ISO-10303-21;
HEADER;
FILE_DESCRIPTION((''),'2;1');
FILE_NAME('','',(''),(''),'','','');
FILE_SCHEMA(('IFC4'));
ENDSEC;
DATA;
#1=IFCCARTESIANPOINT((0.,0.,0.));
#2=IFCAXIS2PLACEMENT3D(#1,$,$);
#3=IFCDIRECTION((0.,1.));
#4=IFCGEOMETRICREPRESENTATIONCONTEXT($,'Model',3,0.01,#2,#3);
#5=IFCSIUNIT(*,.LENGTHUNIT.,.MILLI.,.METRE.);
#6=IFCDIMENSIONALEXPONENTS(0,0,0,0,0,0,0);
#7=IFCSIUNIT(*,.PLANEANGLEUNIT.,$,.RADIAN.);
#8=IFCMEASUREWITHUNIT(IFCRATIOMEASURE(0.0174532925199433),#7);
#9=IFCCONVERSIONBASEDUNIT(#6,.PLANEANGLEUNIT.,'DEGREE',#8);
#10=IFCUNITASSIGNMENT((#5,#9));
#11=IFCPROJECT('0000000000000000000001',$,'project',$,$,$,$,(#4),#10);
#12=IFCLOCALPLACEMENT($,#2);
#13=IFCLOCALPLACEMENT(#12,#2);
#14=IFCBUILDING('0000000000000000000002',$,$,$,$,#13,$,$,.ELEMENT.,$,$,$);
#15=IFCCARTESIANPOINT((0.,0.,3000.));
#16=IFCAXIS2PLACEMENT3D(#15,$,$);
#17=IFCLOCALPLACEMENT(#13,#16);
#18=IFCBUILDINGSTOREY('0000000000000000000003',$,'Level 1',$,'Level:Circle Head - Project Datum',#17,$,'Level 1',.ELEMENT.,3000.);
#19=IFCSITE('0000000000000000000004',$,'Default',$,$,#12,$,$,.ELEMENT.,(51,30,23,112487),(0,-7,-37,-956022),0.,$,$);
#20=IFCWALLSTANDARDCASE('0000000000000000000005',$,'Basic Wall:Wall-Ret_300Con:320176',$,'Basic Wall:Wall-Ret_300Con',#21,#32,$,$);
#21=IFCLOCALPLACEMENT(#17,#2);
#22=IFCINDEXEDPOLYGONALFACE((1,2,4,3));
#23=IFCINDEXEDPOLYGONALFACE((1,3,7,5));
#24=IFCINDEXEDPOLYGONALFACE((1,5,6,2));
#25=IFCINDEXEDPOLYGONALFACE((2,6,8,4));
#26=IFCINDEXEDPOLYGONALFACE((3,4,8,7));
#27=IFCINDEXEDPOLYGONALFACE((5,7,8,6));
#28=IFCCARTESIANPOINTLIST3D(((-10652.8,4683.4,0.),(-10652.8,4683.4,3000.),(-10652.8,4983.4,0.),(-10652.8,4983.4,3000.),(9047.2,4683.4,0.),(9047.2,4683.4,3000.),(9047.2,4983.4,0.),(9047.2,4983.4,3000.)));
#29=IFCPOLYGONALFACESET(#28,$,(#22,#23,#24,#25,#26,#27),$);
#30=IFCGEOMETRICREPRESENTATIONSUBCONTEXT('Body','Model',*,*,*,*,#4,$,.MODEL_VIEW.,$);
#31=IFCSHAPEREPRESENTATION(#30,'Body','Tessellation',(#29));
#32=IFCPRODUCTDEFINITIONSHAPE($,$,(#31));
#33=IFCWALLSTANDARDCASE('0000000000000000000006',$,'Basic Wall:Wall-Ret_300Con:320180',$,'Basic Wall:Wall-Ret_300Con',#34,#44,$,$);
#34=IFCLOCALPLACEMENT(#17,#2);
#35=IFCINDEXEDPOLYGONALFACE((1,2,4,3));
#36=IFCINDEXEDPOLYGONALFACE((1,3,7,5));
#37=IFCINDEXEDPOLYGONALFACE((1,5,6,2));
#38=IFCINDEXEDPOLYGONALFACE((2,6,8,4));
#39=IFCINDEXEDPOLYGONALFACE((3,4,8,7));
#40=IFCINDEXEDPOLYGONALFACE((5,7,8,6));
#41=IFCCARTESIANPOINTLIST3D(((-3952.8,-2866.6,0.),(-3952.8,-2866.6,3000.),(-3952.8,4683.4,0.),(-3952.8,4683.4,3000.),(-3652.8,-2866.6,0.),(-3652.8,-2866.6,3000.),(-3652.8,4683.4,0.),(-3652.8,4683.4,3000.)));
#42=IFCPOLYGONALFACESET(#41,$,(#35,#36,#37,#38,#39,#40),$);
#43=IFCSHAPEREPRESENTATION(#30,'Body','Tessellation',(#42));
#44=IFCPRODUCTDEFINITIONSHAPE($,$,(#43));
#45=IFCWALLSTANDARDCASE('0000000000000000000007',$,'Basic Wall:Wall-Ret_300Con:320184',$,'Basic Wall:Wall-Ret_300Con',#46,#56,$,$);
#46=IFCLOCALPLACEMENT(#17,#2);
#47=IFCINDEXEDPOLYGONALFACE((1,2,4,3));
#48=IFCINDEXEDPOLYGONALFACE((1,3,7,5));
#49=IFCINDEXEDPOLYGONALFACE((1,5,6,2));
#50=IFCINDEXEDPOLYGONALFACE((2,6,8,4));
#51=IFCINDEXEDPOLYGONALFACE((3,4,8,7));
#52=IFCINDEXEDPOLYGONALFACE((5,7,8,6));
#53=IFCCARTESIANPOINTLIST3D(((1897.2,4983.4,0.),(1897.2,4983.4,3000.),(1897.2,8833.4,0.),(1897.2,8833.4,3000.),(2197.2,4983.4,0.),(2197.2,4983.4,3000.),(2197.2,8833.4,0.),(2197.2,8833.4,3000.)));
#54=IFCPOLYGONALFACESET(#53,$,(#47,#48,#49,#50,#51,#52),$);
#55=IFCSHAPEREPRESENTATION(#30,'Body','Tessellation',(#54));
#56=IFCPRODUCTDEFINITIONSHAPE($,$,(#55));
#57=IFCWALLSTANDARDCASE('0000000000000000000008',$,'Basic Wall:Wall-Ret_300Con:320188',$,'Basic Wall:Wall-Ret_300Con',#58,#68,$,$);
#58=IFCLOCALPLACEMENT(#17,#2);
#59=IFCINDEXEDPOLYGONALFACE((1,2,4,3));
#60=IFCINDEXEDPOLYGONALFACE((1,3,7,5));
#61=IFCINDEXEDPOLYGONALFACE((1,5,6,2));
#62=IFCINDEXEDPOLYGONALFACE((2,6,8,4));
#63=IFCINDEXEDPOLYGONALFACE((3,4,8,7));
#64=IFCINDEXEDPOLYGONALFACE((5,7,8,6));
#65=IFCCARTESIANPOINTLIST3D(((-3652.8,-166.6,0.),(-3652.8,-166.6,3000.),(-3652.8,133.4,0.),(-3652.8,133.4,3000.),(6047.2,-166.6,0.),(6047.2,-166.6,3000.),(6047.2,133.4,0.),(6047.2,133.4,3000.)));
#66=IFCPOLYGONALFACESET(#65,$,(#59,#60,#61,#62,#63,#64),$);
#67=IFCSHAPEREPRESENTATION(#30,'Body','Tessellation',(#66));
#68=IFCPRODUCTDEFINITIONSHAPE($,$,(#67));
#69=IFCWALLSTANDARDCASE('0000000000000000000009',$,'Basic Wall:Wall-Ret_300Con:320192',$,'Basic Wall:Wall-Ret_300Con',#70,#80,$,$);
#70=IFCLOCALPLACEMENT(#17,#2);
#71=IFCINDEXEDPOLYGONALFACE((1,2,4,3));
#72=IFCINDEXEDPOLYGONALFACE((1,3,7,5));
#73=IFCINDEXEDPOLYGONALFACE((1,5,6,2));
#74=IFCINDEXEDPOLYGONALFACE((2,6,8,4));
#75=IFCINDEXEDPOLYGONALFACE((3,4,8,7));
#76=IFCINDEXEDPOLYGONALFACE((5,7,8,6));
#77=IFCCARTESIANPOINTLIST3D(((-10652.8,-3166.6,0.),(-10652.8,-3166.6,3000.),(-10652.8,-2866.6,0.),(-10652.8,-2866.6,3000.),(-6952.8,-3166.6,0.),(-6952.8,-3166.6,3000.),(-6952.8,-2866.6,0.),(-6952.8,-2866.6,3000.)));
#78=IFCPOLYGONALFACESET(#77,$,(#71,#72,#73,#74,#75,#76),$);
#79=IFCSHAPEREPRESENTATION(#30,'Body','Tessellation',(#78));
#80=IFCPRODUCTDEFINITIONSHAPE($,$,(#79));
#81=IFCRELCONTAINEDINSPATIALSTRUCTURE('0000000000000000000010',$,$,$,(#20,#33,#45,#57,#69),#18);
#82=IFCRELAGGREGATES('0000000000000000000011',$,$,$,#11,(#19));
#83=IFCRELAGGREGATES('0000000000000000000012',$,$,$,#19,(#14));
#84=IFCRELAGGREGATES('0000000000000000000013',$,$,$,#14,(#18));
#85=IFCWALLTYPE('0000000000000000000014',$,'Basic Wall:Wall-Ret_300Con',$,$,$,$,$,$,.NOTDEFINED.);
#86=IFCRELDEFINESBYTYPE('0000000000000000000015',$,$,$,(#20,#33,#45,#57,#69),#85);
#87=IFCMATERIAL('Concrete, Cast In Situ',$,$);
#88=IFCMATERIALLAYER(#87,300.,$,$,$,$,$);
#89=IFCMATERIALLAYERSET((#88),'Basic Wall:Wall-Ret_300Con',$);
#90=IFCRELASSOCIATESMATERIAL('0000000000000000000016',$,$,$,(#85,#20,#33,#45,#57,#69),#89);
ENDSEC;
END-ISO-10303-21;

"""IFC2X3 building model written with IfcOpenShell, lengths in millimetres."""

from ifc_helpers import new_model, entity, si_unit, converted_unit, direction, frame, frame_2d, origin, place, context, subcontext, project, spatial, rectangle, extrude, material, layer, layer_set, layer_usage, type_object, element, save


model = new_model("IFC2X3")

# Units and contexts
model_context = context("Model", 3, precision=0.01, world=origin(), true_north=direction((0.0, 1.0)))
body_context = subcontext(model_context, "Body", "Model", "MODEL_VIEW")
ifc_project = project(units=[si_unit("LENGTHUNIT", "METRE", prefix="MILLI"), converted_unit("PLANEANGLEUNIT", "DEGREE", entity("IfcRatioMeasure", 0.0174532925199433), si_unit("PLANEANGLEUNIT", "RADIAN"), dimensions=[0, 0, 0, 0, 0, 0, 0])], contexts=[model_context])

# Site, building, storey
site_placement = place(None, origin())
site = spatial("IfcSite", under=ifc_project, at=site_placement, Name="Default", CompositionType="ELEMENT", RefLatitude=(51, 30, 23, 112487), RefLongitude=(0, -7, -37, -956022), RefElevation=0.0)
building_placement = place(site_placement, origin())
building = spatial("IfcBuilding", under=site, at=building_placement, CompositionType="ELEMENT")
storey_placement = place(building_placement, frame((0.0, 0.0, 3000.0)))
storey = spatial("IfcBuildingStorey", under=building, at=storey_placement, Name="Level 1", ObjectType="Level:Circle Head - Project Datum", LongName="Level 1", CompositionType="ELEMENT", Elevation=3000.0)

# Walls
ifc_material_1 = material(Name="Concrete, Cast In Situ")
ifc_layer_1 = layer(ifc_material_1, 300.0)
ifc_layer_set_1 = layer_set([ifc_layer_1], Name="Basic Wall:Wall-Ret_300Con")
wall_type = type_object("IfcWallType", Name="Basic Wall:Wall-Ret_300Con", PredefinedType="NOTDEFINED", material=ifc_layer_set_1)
ifc_layer_usage_1 = layer_usage(ifc_layer_set_1, "AXIS2", "NEGATIVE", 150.0)
wall_1_placement = place(storey_placement, frame((-10652.8, 4833.4, 0.0)))
element("IfcWallStandardCase", 1, at=wall_1_placement, inside=storey, type_object=wall_type, material=ifc_layer_usage_1, Name="Basic Wall:Wall-Ret_300Con:320176", ObjectType="Basic Wall:Wall-Ret_300Con", context=body_context, shape_type="SweptSolid", body=[
    extrude(rectangle(XDim=19700.0, YDim=300.0, at=frame_2d((9850.0, 0.0), x_axis=(-1.0, 0.0))), origin(), (0.0, 0.0, 1.0), 3000.0),
])
ifc_layer_usage_2 = layer_usage(ifc_layer_set_1, "AXIS2", "NEGATIVE", 150.0)
wall_2_placement = place(storey_placement, frame((-3802.8, 4683.4, 0.0), z_axis=(0.0, 0.0, 1.0), x_axis=(0.0, -1.0, 0.0)))
element("IfcWallStandardCase", 2, at=wall_2_placement, inside=storey, type_object=wall_type, material=ifc_layer_usage_2, Name="Basic Wall:Wall-Ret_300Con:320180", ObjectType="Basic Wall:Wall-Ret_300Con", context=body_context, shape_type="SweptSolid", body=[
    extrude(rectangle(XDim=7550.0, YDim=300.0, at=frame_2d((3775.0, 0.0), x_axis=(-1.0, 0.0))), origin(), (0.0, 0.0, 1.0), 3000.0),
])
ifc_layer_usage_3 = layer_usage(ifc_layer_set_1, "AXIS2", "NEGATIVE", 150.0)
wall_3_placement = place(storey_placement, frame((2047.2, 4983.4, 0.0), z_axis=(0.0, 0.0, 1.0), x_axis=(0.0, 1.0, 0.0)))
element("IfcWallStandardCase", 3, at=wall_3_placement, inside=storey, type_object=wall_type, material=ifc_layer_usage_3, Name="Basic Wall:Wall-Ret_300Con:320184", ObjectType="Basic Wall:Wall-Ret_300Con", context=body_context, shape_type="SweptSolid", body=[
    extrude(rectangle(XDim=3850.0, YDim=300.0, at=frame_2d((1925.0, 0.0), x_axis=(-1.0, 0.0))), origin(), (0.0, 0.0, 1.0), 3000.0),
])
ifc_layer_usage_4 = layer_usage(ifc_layer_set_1, "AXIS2", "NEGATIVE", 150.0)
wall_4_placement = place(storey_placement, frame((6047.2, -16.6, 0.0), z_axis=(0.0, 0.0, 1.0), x_axis=(-1.0, 0.0, 0.0)))
element("IfcWallStandardCase", 4, at=wall_4_placement, inside=storey, type_object=wall_type, material=ifc_layer_usage_4, Name="Basic Wall:Wall-Ret_300Con:320188", ObjectType="Basic Wall:Wall-Ret_300Con", context=body_context, shape_type="SweptSolid", body=[
    extrude(rectangle(XDim=9700.0, YDim=300.0, at=frame_2d((4850.0, 0.0), x_axis=(-1.0, 0.0))), origin(), (0.0, 0.0, 1.0), 3000.0),
])
ifc_layer_usage_5 = layer_usage(ifc_layer_set_1, "AXIS2", "NEGATIVE", 150.0)
wall_5_placement = place(storey_placement, frame((-6952.8, -3016.6, 0.0), z_axis=(0.0, 0.0, 1.0), x_axis=(-1.0, 0.0, 0.0)))
element("IfcWallStandardCase", 5, at=wall_5_placement, inside=storey, type_object=wall_type, material=ifc_layer_usage_5, Name="Basic Wall:Wall-Ret_300Con:320192", ObjectType="Basic Wall:Wall-Ret_300Con", context=body_context, shape_type="SweptSolid", body=[
    extrude(rectangle(XDim=3700.0, YDim=300.0, at=frame_2d((1850.0, 0.0), x_axis=(-1.0, 0.0))), origin(), (0.0, 0.0, 1.0), 3000.0),
])

save(model, "model.ifc")
